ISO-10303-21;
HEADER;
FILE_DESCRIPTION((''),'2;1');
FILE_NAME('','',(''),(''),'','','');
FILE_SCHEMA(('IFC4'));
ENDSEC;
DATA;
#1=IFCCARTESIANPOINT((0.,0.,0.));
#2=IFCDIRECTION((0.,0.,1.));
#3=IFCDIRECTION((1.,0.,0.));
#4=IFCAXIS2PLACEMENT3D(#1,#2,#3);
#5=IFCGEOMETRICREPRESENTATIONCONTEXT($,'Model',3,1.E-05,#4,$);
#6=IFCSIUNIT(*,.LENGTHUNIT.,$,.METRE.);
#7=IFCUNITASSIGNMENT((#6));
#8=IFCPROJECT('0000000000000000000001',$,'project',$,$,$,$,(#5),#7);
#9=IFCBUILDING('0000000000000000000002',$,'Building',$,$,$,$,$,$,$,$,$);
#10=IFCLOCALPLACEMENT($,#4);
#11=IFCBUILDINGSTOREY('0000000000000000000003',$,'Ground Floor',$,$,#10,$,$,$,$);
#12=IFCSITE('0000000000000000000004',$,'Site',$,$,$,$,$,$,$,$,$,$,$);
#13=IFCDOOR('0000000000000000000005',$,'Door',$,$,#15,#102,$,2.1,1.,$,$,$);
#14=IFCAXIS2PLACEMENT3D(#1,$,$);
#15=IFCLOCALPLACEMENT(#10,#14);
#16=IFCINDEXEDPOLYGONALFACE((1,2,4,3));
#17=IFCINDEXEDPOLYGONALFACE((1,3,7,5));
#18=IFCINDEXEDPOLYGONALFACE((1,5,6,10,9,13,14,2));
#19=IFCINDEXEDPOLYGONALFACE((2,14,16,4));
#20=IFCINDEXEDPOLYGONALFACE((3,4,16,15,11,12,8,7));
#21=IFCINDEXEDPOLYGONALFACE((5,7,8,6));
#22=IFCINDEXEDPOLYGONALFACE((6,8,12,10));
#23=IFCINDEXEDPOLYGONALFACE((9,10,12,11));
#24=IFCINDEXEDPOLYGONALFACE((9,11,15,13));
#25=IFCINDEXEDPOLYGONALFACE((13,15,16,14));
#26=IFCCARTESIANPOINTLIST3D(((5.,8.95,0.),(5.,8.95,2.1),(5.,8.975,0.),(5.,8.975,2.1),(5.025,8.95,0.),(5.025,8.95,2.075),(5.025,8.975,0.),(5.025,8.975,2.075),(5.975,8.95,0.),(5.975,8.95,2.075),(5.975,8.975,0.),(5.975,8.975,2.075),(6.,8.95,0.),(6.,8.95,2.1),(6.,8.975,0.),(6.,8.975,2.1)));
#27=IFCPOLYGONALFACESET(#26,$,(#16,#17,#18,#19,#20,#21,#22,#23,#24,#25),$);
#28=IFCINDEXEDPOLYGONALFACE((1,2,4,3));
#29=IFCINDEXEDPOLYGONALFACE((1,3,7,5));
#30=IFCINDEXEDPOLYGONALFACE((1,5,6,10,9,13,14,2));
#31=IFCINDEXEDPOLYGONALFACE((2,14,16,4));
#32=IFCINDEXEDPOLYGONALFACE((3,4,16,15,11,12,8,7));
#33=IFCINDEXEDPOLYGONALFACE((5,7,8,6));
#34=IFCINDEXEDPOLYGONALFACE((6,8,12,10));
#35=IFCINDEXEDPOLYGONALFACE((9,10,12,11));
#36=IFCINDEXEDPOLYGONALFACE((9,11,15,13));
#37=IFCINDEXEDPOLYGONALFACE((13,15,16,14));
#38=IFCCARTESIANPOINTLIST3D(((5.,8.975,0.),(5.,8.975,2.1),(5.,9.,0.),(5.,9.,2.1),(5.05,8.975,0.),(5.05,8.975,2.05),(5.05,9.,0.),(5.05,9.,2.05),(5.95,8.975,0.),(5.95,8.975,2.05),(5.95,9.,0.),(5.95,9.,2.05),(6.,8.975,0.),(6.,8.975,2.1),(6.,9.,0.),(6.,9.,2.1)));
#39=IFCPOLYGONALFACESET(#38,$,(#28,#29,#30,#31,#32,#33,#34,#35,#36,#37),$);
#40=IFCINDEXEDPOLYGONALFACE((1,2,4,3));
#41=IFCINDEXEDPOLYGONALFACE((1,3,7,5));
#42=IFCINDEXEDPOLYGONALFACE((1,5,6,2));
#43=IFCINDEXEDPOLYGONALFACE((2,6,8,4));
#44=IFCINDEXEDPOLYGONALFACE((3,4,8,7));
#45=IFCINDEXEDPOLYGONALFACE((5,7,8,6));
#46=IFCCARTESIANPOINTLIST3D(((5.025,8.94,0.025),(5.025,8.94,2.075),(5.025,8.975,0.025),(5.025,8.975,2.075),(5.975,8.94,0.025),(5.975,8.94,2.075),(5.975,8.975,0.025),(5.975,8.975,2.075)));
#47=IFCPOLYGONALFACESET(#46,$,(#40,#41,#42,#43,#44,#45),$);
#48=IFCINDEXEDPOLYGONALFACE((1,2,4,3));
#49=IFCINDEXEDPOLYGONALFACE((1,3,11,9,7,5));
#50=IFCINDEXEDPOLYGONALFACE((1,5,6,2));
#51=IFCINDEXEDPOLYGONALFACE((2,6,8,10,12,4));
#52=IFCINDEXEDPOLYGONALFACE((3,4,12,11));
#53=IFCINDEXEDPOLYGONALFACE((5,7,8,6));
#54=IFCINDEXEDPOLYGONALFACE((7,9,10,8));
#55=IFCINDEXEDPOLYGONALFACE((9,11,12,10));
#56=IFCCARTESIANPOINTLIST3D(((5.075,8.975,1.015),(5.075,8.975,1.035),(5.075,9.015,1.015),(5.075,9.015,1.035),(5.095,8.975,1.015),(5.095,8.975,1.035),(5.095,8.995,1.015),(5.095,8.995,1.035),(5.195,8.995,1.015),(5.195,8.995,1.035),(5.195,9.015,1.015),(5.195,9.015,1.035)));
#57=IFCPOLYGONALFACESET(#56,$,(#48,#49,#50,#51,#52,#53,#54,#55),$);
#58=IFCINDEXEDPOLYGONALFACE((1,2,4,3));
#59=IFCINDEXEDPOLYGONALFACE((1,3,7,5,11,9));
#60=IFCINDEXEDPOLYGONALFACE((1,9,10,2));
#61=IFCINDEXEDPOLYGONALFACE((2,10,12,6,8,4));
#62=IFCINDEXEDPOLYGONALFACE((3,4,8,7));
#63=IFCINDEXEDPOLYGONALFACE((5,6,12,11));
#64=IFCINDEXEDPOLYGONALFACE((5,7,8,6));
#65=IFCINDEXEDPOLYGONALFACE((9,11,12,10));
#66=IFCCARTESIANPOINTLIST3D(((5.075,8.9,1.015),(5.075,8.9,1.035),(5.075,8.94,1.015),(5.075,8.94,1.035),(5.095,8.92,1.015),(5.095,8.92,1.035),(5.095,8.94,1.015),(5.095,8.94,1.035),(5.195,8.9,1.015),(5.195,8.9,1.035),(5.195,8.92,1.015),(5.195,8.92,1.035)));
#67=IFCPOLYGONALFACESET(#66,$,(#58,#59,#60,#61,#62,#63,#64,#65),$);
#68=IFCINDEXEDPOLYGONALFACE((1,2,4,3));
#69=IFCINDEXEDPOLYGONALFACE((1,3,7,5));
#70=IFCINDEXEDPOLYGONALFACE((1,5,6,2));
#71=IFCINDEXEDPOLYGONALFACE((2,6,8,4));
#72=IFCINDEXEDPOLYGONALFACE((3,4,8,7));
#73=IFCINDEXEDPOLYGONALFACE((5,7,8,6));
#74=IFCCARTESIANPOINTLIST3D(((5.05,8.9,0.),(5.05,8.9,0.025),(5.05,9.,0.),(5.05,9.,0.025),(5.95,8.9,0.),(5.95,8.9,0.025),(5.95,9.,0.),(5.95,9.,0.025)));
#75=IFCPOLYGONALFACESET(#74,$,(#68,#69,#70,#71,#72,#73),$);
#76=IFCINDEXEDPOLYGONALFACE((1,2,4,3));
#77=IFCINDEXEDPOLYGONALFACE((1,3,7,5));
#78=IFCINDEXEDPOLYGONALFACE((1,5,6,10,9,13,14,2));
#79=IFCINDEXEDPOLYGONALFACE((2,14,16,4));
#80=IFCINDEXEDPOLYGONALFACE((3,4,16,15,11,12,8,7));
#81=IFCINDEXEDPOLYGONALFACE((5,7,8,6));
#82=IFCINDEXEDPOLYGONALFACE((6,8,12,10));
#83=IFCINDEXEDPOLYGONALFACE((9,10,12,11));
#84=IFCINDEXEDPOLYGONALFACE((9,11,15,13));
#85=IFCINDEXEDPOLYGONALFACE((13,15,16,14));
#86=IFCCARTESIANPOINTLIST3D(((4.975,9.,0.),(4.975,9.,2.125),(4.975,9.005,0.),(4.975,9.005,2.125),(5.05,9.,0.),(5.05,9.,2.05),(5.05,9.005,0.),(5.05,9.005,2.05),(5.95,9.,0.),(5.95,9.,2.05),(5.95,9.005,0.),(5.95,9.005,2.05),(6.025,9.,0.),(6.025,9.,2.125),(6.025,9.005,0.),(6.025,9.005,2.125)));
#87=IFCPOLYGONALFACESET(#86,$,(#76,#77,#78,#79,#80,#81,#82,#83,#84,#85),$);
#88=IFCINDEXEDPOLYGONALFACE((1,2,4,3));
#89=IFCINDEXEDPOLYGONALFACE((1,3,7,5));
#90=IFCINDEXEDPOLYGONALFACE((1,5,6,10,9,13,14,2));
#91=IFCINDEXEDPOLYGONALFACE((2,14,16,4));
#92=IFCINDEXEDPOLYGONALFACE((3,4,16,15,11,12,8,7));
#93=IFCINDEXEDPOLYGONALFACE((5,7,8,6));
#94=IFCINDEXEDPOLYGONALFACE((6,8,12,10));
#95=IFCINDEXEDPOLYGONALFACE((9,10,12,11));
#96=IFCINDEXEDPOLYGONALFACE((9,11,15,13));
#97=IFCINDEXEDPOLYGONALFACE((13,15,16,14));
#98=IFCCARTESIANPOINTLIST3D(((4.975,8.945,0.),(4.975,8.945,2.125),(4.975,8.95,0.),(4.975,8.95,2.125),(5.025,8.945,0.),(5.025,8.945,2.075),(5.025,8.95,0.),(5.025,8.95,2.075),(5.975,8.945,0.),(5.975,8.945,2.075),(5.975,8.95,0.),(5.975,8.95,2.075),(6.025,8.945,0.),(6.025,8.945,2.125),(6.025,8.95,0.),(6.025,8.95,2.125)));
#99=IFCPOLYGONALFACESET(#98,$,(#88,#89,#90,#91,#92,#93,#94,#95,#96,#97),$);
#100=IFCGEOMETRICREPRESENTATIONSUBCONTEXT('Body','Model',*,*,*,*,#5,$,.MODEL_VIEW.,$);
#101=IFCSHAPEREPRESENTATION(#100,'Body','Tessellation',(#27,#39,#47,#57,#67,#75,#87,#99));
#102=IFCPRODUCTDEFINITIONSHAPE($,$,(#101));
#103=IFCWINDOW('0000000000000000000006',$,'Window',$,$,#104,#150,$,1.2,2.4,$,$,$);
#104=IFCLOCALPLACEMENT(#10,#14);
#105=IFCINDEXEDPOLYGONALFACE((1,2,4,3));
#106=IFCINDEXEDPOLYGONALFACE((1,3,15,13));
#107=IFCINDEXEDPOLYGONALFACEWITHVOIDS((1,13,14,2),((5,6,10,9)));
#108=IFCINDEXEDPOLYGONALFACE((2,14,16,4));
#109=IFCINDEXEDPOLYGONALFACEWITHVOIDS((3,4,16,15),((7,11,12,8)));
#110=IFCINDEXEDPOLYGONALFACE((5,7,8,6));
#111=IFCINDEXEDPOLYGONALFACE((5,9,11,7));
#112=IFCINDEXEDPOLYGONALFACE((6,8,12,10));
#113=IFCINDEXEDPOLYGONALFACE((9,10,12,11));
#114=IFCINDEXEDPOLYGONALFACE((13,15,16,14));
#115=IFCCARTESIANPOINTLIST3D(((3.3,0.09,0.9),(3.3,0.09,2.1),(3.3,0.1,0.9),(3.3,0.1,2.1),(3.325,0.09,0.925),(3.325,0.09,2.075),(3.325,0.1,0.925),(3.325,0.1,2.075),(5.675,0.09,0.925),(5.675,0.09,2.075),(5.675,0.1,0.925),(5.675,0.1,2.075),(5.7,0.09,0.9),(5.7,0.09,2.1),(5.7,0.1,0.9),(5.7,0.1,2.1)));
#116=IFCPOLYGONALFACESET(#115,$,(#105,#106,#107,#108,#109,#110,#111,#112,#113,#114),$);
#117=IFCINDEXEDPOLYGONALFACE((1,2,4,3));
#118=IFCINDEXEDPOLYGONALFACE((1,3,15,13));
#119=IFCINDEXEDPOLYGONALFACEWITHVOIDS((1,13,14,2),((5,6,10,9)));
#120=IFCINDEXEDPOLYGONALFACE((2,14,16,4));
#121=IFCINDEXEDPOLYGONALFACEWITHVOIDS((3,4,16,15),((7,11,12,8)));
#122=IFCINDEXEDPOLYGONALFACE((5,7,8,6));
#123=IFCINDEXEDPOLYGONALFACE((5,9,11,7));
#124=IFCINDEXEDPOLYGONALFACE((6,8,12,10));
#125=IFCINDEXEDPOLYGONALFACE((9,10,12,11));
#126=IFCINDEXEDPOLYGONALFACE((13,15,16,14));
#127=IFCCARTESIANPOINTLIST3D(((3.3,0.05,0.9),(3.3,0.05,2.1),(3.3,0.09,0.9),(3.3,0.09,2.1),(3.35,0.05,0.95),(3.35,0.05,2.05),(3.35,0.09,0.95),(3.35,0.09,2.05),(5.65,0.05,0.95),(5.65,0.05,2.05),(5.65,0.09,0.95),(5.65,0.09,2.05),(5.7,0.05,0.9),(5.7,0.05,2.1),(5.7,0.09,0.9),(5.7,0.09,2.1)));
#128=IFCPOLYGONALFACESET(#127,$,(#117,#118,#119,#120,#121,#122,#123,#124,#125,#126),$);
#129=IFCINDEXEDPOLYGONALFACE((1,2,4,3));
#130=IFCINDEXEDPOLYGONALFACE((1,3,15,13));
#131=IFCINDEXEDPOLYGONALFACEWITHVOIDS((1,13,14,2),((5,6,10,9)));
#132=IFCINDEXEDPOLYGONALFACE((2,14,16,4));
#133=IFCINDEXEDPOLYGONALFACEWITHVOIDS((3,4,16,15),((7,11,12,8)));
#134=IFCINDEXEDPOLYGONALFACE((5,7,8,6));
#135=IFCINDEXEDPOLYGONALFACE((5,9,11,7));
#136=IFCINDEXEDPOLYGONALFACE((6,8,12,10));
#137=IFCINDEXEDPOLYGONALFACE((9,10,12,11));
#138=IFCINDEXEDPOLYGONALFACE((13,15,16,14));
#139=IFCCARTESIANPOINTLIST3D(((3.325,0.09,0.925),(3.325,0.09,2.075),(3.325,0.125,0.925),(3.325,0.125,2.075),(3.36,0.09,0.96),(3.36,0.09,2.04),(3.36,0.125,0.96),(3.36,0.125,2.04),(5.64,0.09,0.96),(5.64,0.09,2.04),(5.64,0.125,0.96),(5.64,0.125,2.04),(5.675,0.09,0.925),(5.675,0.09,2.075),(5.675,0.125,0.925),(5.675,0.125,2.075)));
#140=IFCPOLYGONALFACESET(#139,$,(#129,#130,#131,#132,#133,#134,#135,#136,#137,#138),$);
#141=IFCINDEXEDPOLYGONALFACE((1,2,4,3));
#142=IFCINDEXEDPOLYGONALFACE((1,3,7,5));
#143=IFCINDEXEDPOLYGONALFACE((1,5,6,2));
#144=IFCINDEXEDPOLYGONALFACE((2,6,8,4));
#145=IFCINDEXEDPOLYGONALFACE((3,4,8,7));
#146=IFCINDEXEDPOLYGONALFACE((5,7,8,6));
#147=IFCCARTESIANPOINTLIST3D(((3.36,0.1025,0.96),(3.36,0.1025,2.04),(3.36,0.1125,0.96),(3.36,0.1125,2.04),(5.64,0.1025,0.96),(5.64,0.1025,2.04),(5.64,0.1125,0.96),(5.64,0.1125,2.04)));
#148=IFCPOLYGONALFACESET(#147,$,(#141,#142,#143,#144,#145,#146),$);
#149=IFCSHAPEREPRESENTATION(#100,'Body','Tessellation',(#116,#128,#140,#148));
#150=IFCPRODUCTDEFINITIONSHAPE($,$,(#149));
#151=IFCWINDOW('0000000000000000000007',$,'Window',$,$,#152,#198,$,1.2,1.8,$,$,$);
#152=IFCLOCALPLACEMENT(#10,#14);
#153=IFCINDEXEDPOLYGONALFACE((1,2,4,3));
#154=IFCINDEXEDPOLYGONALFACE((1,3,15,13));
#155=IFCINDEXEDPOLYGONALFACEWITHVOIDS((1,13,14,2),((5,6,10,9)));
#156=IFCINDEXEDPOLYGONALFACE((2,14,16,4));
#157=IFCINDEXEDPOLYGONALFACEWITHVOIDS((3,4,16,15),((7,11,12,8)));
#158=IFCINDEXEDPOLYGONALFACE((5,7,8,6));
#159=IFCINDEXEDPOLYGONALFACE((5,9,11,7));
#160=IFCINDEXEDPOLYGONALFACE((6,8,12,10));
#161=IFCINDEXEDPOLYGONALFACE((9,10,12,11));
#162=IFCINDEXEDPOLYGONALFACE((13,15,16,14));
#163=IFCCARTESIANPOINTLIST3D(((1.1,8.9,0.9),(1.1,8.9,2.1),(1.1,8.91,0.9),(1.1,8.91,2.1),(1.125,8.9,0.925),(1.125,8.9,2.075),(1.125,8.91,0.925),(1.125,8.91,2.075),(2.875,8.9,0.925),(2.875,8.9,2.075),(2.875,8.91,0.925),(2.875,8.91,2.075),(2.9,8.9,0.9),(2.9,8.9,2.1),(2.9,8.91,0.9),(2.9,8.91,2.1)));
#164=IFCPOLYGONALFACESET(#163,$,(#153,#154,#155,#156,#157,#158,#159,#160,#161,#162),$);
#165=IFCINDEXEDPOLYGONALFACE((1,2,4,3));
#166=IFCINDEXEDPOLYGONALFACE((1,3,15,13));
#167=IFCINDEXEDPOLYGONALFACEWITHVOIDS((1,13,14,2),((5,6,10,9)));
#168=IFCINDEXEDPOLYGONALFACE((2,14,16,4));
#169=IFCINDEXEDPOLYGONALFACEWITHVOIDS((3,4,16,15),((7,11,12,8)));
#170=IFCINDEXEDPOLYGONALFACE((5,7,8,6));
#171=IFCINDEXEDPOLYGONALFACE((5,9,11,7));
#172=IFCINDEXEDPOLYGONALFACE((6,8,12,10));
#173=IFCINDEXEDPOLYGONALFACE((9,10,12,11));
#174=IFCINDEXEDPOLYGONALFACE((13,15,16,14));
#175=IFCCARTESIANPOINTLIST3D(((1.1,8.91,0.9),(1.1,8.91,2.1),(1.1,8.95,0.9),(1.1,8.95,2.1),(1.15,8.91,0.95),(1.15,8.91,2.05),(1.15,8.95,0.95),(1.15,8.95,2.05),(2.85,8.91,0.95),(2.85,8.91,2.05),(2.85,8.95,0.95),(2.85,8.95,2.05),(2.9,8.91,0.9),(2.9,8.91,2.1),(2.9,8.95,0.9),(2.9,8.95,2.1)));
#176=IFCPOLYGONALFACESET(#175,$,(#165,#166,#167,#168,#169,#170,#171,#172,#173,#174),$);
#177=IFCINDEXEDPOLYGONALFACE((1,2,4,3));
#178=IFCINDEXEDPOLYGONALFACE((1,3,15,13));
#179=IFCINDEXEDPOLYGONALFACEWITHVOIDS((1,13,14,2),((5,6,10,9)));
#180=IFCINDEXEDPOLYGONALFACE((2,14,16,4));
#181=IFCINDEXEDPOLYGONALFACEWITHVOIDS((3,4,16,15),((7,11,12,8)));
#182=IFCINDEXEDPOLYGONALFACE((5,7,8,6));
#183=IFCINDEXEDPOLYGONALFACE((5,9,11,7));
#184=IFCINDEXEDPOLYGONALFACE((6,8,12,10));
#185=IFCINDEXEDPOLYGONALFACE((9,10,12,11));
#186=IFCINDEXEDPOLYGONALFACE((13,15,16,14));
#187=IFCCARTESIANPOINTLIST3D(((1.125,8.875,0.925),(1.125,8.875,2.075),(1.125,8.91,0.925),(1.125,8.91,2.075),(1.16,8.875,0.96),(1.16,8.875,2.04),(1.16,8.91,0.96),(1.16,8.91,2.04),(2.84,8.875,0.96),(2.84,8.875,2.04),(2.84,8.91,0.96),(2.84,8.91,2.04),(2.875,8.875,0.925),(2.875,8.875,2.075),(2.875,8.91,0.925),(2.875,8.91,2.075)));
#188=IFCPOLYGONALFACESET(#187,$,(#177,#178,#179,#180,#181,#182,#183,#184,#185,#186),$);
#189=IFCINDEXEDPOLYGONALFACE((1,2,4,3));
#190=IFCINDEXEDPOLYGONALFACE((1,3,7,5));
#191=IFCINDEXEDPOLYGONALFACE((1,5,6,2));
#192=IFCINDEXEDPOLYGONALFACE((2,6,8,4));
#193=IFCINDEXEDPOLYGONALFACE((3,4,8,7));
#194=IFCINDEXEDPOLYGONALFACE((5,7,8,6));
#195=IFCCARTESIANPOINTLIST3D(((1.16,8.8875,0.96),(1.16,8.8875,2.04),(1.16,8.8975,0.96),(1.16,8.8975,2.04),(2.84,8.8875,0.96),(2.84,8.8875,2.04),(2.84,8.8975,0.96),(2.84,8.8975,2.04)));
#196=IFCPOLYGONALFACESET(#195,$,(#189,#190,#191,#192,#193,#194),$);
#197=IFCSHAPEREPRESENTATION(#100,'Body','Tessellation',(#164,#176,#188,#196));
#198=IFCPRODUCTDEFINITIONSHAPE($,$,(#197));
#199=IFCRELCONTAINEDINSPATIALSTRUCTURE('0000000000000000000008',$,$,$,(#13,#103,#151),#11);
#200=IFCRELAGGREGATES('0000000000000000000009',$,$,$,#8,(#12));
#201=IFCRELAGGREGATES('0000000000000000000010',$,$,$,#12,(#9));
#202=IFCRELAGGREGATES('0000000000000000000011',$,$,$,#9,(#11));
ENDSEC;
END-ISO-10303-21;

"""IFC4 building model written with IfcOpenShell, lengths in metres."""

from ifc_helpers import new_model, si_unit, frame, origin_with_axes, place, context, subcontext, project, spatial, line, indexed_curve, outline, extrude, element, save


model = new_model("IFC4")

# Units and contexts
model_context = context("Model", 3, precision=1e-05, world=origin_with_axes())
body_context = subcontext(model_context, "Body", "Model", "MODEL_VIEW")
ifc_project = project(units=[si_unit("LENGTHUNIT", "METRE")], contexts=[model_context])

# Site, building, storey
site = spatial("IfcSite", under=ifc_project, Name="Site")
building = spatial("IfcBuilding", under=site, Name="Building")
storey_placement = place(None, origin_with_axes())
storey = spatial("IfcBuildingStorey", under=building, at=storey_placement, Name="Ground Floor")

# Door
door_1_placement = place(storey_placement, frame((6.0, 9.0, 0.0), z_axis=(0.0, 0.0, 1.0), x_axis=(-1.0, 0.0, 0.0)))
element("IfcDoor", 1, at=door_1_placement, inside=storey, Name="Door", OverallHeight=2.1, OverallWidth=1.0, context=body_context, shape_type="SweptSolid", body=[
    extrude(outline(indexed_curve([(0.0, 0.0), (0.0, 2.1), (1.0, 2.1), (1.0, 0.0), (0.975, 0.0), (0.975, 2.075), (0.025, 2.075), (0.025, 0.0)], segments=[line(1, 2, 3, 4, 5, 6, 7, 8, 1)])), frame((0.0, 0.025, 0.0), z_axis=(0.0, -1.0, 0.0), x_axis=(1.0, 0.0, 0.0)), (0.0, 0.0, -1.0), 0.025),
    extrude(outline(indexed_curve([(0.0, 0.0), (0.0, 2.1), (1.0, 2.1), (1.0, 0.0), (0.95, 0.0), (0.95, 2.05), (0.05, 2.05), (0.05, 0.0)], segments=[line(1, 2, 3, 4, 5, 6, 7, 8, 1)])), frame((0.0, 0.0, 0.0), z_axis=(0.0, -1.0, 0.0), x_axis=(1.0, 0.0, 0.0)), (0.0, 0.0, -1.0), 0.025),
    extrude(outline(indexed_curve([(0.0, 0.0), (0.95, 0.0), (0.95, 0.035), (0.0, 0.035)], segments=[line(1, 2, 3, 4, 1)])), frame((0.025, 0.025, 0.025), z_axis=(0.0, 0.0, 1.0), x_axis=(1.0, 0.0, 0.0)), (0.0, 0.0, 1.0), 2.05),
    extrude(outline(indexed_curve([(0.0, 0.0), (0.0, -0.04), (-0.12, -0.04), (-0.12, -0.02), (-0.02, -0.02), (-0.02, 0.0)], segments=[line(1, 2, 3, 4, 5, 6, 1)])), frame((0.925, 0.025, 1.015), z_axis=(0.0, 0.0, 1.0), x_axis=(1.0, 0.0, 0.0)), (0.0, 0.0, 1.0), 0.02),
    extrude(outline(indexed_curve([(0.0, 0.0), (0.0, 0.04), (-0.12, 0.04), (-0.12, 0.02), (-0.02, 0.02), (-0.02, 0.0)], segments=[line(1, 2, 3, 4, 5, 6, 1)])), frame((0.925, 0.06, 1.015), z_axis=(0.0, 0.0, 1.0), x_axis=(1.0, 0.0, 0.0)), (0.0, 0.0, 1.0), 0.02),
    extrude(outline(indexed_curve([(0.0, 0.0), (0.9, 0.0), (0.9, 0.1), (0.0, 0.1)], segments=[line(1, 2, 3, 4, 1)])), frame((0.05, 0.0, 0.0), z_axis=(0.0, 0.0, 1.0), x_axis=(1.0, 0.0, 0.0)), (0.0, 0.0, 1.0), 0.025),
    extrude(outline(indexed_curve([(0.0, 0.0), (0.0, 2.125), (1.05, 2.125), (1.05, 0.0), (0.975, 0.0), (0.975, 2.05), (0.075, 2.05), (0.075, 0.0)], segments=[line(1, 2, 3, 4, 5, 6, 7, 8, 1)])), frame((-0.025, -0.005, 0.0), z_axis=(0.0, -1.0, 0.0), x_axis=(1.0, 0.0, 0.0)), (0.0, 0.0, -1.0), 0.005),
    extrude(outline(indexed_curve([(0.0, 0.0), (0.0, 2.125), (1.05, 2.125), (1.05, 0.0), (1.0, 0.0), (1.0, 2.075), (0.05, 2.075), (0.05, 0.0)], segments=[line(1, 2, 3, 4, 5, 6, 7, 8, 1)])), frame((-0.025, 0.05, 0.0), z_axis=(0.0, -1.0, 0.0), x_axis=(1.0, 0.0, 0.0)), (0.0, 0.0, -1.0), 0.005),
])

# Windows
window_1_placement = place(storey_placement, frame((3.3, 0.0, 0.9), z_axis=(0.0, 0.0, 1.0), x_axis=(1.0, 0.0, 0.0)))
element("IfcWindow", 2, at=window_1_placement, inside=storey, Name="Window", OverallHeight=1.2, OverallWidth=2.4, context=body_context, shape_type="SweptSolid", body=[
    extrude(outline(indexed_curve([(0.0, 0.0), (2.4, 0.0), (2.4, 1.2), (0.0, 1.2)], segments=[line(1, 2, 3, 4, 1)]), holes=[indexed_curve([(0.025, 0.025), (2.375, 0.025), (2.375, 1.175), (0.025, 1.175)], segments=[line(1, 2, 3, 4, 1)])]), frame((0.0, 0.09, 0.0), z_axis=(0.0, -1.0, 0.0), x_axis=(1.0, 0.0, 0.0)), (0.0, 0.0, -1.0), 0.01),
    extrude(outline(indexed_curve([(0.0, 0.0), (2.4, 0.0), (2.4, 1.2), (0.0, 1.2)], segments=[line(1, 2, 3, 4, 1)]), holes=[indexed_curve([(0.05, 0.05), (2.35, 0.05), (2.35, 1.15), (0.05, 1.15)], segments=[line(1, 2, 3, 4, 1)])]), frame((0.0, 0.05, 0.0), z_axis=(0.0, -1.0, 0.0), x_axis=(1.0, 0.0, 0.0)), (0.0, 0.0, -1.0), 0.04),
    extrude(outline(indexed_curve([(0.0, 0.0), (2.35, 0.0), (2.35, 1.15), (0.0, 1.15)], segments=[line(1, 2, 3, 4, 1)]), holes=[indexed_curve([(0.035, 0.035), (2.315, 0.035), (2.315, 1.115), (0.035, 1.115)], segments=[line(1, 2, 3, 4, 1)])]), frame((0.025, 0.09, 0.025), z_axis=(0.0, -1.0, 0.0), x_axis=(1.0, 0.0, 0.0)), (0.0, 0.0, -1.0), 0.035),
    extrude(outline(indexed_curve([(0.035, 0.035), (2.315, 0.035), (2.315, 1.115), (0.035, 1.115)], segments=[line(1, 2, 3, 4, 1)])), frame((0.025, 0.1025, 0.025), z_axis=(0.0, -1.0, 0.0), x_axis=(1.0, 0.0, 0.0)), (0.0, 0.0, -1.0), 0.01),
])
window_2_placement = place(storey_placement, frame((2.9, 9.0, 0.9), z_axis=(0.0, 0.0, 1.0), x_axis=(-1.0, 0.0, 0.0)))
element("IfcWindow", 3, at=window_2_placement, inside=storey, Name="Window", OverallHeight=1.2, OverallWidth=1.8, context=body_context, shape_type="SweptSolid", body=[
    extrude(outline(indexed_curve([(0.0, 0.0), (1.8, 0.0), (1.8, 1.2), (0.0, 1.2)], segments=[line(1, 2, 3, 4, 1)]), holes=[indexed_curve([(0.025, 0.025), (1.775, 0.025), (1.775, 1.175), (0.025, 1.175)], segments=[line(1, 2, 3, 4, 1)])]), frame((0.0, 0.09, 0.0), z_axis=(0.0, -1.0, 0.0), x_axis=(1.0, 0.0, 0.0)), (0.0, 0.0, -1.0), 0.01),
    extrude(outline(indexed_curve([(0.0, 0.0), (1.8, 0.0), (1.8, 1.2), (0.0, 1.2)], segments=[line(1, 2, 3, 4, 1)]), holes=[indexed_curve([(0.05, 0.05), (1.75, 0.05), (1.75, 1.15), (0.05, 1.15)], segments=[line(1, 2, 3, 4, 1)])]), frame((0.0, 0.05, 0.0), z_axis=(0.0, -1.0, 0.0), x_axis=(1.0, 0.0, 0.0)), (0.0, 0.0, -1.0), 0.04),
    extrude(outline(indexed_curve([(0.0, 0.0), (1.75, 0.0), (1.75, 1.15), (0.0, 1.15)], segments=[line(1, 2, 3, 4, 1)]), holes=[indexed_curve([(0.035, 0.035), (1.715, 0.035), (1.715, 1.115), (0.035, 1.115)], segments=[line(1, 2, 3, 4, 1)])]), frame((0.025, 0.09, 0.025), z_axis=(0.0, -1.0, 0.0), x_axis=(1.0, 0.0, 0.0)), (0.0, 0.0, -1.0), 0.035),
    extrude(outline(indexed_curve([(0.035, 0.035), (1.715, 0.035), (1.715, 1.115), (0.035, 1.115)], segments=[line(1, 2, 3, 4, 1)])), frame((0.025, 0.1025, 0.025), z_axis=(0.0, -1.0, 0.0), x_axis=(1.0, 0.0, 0.0)), (0.0, 0.0, -1.0), 0.01),
])

save(model, "model.ifc")
